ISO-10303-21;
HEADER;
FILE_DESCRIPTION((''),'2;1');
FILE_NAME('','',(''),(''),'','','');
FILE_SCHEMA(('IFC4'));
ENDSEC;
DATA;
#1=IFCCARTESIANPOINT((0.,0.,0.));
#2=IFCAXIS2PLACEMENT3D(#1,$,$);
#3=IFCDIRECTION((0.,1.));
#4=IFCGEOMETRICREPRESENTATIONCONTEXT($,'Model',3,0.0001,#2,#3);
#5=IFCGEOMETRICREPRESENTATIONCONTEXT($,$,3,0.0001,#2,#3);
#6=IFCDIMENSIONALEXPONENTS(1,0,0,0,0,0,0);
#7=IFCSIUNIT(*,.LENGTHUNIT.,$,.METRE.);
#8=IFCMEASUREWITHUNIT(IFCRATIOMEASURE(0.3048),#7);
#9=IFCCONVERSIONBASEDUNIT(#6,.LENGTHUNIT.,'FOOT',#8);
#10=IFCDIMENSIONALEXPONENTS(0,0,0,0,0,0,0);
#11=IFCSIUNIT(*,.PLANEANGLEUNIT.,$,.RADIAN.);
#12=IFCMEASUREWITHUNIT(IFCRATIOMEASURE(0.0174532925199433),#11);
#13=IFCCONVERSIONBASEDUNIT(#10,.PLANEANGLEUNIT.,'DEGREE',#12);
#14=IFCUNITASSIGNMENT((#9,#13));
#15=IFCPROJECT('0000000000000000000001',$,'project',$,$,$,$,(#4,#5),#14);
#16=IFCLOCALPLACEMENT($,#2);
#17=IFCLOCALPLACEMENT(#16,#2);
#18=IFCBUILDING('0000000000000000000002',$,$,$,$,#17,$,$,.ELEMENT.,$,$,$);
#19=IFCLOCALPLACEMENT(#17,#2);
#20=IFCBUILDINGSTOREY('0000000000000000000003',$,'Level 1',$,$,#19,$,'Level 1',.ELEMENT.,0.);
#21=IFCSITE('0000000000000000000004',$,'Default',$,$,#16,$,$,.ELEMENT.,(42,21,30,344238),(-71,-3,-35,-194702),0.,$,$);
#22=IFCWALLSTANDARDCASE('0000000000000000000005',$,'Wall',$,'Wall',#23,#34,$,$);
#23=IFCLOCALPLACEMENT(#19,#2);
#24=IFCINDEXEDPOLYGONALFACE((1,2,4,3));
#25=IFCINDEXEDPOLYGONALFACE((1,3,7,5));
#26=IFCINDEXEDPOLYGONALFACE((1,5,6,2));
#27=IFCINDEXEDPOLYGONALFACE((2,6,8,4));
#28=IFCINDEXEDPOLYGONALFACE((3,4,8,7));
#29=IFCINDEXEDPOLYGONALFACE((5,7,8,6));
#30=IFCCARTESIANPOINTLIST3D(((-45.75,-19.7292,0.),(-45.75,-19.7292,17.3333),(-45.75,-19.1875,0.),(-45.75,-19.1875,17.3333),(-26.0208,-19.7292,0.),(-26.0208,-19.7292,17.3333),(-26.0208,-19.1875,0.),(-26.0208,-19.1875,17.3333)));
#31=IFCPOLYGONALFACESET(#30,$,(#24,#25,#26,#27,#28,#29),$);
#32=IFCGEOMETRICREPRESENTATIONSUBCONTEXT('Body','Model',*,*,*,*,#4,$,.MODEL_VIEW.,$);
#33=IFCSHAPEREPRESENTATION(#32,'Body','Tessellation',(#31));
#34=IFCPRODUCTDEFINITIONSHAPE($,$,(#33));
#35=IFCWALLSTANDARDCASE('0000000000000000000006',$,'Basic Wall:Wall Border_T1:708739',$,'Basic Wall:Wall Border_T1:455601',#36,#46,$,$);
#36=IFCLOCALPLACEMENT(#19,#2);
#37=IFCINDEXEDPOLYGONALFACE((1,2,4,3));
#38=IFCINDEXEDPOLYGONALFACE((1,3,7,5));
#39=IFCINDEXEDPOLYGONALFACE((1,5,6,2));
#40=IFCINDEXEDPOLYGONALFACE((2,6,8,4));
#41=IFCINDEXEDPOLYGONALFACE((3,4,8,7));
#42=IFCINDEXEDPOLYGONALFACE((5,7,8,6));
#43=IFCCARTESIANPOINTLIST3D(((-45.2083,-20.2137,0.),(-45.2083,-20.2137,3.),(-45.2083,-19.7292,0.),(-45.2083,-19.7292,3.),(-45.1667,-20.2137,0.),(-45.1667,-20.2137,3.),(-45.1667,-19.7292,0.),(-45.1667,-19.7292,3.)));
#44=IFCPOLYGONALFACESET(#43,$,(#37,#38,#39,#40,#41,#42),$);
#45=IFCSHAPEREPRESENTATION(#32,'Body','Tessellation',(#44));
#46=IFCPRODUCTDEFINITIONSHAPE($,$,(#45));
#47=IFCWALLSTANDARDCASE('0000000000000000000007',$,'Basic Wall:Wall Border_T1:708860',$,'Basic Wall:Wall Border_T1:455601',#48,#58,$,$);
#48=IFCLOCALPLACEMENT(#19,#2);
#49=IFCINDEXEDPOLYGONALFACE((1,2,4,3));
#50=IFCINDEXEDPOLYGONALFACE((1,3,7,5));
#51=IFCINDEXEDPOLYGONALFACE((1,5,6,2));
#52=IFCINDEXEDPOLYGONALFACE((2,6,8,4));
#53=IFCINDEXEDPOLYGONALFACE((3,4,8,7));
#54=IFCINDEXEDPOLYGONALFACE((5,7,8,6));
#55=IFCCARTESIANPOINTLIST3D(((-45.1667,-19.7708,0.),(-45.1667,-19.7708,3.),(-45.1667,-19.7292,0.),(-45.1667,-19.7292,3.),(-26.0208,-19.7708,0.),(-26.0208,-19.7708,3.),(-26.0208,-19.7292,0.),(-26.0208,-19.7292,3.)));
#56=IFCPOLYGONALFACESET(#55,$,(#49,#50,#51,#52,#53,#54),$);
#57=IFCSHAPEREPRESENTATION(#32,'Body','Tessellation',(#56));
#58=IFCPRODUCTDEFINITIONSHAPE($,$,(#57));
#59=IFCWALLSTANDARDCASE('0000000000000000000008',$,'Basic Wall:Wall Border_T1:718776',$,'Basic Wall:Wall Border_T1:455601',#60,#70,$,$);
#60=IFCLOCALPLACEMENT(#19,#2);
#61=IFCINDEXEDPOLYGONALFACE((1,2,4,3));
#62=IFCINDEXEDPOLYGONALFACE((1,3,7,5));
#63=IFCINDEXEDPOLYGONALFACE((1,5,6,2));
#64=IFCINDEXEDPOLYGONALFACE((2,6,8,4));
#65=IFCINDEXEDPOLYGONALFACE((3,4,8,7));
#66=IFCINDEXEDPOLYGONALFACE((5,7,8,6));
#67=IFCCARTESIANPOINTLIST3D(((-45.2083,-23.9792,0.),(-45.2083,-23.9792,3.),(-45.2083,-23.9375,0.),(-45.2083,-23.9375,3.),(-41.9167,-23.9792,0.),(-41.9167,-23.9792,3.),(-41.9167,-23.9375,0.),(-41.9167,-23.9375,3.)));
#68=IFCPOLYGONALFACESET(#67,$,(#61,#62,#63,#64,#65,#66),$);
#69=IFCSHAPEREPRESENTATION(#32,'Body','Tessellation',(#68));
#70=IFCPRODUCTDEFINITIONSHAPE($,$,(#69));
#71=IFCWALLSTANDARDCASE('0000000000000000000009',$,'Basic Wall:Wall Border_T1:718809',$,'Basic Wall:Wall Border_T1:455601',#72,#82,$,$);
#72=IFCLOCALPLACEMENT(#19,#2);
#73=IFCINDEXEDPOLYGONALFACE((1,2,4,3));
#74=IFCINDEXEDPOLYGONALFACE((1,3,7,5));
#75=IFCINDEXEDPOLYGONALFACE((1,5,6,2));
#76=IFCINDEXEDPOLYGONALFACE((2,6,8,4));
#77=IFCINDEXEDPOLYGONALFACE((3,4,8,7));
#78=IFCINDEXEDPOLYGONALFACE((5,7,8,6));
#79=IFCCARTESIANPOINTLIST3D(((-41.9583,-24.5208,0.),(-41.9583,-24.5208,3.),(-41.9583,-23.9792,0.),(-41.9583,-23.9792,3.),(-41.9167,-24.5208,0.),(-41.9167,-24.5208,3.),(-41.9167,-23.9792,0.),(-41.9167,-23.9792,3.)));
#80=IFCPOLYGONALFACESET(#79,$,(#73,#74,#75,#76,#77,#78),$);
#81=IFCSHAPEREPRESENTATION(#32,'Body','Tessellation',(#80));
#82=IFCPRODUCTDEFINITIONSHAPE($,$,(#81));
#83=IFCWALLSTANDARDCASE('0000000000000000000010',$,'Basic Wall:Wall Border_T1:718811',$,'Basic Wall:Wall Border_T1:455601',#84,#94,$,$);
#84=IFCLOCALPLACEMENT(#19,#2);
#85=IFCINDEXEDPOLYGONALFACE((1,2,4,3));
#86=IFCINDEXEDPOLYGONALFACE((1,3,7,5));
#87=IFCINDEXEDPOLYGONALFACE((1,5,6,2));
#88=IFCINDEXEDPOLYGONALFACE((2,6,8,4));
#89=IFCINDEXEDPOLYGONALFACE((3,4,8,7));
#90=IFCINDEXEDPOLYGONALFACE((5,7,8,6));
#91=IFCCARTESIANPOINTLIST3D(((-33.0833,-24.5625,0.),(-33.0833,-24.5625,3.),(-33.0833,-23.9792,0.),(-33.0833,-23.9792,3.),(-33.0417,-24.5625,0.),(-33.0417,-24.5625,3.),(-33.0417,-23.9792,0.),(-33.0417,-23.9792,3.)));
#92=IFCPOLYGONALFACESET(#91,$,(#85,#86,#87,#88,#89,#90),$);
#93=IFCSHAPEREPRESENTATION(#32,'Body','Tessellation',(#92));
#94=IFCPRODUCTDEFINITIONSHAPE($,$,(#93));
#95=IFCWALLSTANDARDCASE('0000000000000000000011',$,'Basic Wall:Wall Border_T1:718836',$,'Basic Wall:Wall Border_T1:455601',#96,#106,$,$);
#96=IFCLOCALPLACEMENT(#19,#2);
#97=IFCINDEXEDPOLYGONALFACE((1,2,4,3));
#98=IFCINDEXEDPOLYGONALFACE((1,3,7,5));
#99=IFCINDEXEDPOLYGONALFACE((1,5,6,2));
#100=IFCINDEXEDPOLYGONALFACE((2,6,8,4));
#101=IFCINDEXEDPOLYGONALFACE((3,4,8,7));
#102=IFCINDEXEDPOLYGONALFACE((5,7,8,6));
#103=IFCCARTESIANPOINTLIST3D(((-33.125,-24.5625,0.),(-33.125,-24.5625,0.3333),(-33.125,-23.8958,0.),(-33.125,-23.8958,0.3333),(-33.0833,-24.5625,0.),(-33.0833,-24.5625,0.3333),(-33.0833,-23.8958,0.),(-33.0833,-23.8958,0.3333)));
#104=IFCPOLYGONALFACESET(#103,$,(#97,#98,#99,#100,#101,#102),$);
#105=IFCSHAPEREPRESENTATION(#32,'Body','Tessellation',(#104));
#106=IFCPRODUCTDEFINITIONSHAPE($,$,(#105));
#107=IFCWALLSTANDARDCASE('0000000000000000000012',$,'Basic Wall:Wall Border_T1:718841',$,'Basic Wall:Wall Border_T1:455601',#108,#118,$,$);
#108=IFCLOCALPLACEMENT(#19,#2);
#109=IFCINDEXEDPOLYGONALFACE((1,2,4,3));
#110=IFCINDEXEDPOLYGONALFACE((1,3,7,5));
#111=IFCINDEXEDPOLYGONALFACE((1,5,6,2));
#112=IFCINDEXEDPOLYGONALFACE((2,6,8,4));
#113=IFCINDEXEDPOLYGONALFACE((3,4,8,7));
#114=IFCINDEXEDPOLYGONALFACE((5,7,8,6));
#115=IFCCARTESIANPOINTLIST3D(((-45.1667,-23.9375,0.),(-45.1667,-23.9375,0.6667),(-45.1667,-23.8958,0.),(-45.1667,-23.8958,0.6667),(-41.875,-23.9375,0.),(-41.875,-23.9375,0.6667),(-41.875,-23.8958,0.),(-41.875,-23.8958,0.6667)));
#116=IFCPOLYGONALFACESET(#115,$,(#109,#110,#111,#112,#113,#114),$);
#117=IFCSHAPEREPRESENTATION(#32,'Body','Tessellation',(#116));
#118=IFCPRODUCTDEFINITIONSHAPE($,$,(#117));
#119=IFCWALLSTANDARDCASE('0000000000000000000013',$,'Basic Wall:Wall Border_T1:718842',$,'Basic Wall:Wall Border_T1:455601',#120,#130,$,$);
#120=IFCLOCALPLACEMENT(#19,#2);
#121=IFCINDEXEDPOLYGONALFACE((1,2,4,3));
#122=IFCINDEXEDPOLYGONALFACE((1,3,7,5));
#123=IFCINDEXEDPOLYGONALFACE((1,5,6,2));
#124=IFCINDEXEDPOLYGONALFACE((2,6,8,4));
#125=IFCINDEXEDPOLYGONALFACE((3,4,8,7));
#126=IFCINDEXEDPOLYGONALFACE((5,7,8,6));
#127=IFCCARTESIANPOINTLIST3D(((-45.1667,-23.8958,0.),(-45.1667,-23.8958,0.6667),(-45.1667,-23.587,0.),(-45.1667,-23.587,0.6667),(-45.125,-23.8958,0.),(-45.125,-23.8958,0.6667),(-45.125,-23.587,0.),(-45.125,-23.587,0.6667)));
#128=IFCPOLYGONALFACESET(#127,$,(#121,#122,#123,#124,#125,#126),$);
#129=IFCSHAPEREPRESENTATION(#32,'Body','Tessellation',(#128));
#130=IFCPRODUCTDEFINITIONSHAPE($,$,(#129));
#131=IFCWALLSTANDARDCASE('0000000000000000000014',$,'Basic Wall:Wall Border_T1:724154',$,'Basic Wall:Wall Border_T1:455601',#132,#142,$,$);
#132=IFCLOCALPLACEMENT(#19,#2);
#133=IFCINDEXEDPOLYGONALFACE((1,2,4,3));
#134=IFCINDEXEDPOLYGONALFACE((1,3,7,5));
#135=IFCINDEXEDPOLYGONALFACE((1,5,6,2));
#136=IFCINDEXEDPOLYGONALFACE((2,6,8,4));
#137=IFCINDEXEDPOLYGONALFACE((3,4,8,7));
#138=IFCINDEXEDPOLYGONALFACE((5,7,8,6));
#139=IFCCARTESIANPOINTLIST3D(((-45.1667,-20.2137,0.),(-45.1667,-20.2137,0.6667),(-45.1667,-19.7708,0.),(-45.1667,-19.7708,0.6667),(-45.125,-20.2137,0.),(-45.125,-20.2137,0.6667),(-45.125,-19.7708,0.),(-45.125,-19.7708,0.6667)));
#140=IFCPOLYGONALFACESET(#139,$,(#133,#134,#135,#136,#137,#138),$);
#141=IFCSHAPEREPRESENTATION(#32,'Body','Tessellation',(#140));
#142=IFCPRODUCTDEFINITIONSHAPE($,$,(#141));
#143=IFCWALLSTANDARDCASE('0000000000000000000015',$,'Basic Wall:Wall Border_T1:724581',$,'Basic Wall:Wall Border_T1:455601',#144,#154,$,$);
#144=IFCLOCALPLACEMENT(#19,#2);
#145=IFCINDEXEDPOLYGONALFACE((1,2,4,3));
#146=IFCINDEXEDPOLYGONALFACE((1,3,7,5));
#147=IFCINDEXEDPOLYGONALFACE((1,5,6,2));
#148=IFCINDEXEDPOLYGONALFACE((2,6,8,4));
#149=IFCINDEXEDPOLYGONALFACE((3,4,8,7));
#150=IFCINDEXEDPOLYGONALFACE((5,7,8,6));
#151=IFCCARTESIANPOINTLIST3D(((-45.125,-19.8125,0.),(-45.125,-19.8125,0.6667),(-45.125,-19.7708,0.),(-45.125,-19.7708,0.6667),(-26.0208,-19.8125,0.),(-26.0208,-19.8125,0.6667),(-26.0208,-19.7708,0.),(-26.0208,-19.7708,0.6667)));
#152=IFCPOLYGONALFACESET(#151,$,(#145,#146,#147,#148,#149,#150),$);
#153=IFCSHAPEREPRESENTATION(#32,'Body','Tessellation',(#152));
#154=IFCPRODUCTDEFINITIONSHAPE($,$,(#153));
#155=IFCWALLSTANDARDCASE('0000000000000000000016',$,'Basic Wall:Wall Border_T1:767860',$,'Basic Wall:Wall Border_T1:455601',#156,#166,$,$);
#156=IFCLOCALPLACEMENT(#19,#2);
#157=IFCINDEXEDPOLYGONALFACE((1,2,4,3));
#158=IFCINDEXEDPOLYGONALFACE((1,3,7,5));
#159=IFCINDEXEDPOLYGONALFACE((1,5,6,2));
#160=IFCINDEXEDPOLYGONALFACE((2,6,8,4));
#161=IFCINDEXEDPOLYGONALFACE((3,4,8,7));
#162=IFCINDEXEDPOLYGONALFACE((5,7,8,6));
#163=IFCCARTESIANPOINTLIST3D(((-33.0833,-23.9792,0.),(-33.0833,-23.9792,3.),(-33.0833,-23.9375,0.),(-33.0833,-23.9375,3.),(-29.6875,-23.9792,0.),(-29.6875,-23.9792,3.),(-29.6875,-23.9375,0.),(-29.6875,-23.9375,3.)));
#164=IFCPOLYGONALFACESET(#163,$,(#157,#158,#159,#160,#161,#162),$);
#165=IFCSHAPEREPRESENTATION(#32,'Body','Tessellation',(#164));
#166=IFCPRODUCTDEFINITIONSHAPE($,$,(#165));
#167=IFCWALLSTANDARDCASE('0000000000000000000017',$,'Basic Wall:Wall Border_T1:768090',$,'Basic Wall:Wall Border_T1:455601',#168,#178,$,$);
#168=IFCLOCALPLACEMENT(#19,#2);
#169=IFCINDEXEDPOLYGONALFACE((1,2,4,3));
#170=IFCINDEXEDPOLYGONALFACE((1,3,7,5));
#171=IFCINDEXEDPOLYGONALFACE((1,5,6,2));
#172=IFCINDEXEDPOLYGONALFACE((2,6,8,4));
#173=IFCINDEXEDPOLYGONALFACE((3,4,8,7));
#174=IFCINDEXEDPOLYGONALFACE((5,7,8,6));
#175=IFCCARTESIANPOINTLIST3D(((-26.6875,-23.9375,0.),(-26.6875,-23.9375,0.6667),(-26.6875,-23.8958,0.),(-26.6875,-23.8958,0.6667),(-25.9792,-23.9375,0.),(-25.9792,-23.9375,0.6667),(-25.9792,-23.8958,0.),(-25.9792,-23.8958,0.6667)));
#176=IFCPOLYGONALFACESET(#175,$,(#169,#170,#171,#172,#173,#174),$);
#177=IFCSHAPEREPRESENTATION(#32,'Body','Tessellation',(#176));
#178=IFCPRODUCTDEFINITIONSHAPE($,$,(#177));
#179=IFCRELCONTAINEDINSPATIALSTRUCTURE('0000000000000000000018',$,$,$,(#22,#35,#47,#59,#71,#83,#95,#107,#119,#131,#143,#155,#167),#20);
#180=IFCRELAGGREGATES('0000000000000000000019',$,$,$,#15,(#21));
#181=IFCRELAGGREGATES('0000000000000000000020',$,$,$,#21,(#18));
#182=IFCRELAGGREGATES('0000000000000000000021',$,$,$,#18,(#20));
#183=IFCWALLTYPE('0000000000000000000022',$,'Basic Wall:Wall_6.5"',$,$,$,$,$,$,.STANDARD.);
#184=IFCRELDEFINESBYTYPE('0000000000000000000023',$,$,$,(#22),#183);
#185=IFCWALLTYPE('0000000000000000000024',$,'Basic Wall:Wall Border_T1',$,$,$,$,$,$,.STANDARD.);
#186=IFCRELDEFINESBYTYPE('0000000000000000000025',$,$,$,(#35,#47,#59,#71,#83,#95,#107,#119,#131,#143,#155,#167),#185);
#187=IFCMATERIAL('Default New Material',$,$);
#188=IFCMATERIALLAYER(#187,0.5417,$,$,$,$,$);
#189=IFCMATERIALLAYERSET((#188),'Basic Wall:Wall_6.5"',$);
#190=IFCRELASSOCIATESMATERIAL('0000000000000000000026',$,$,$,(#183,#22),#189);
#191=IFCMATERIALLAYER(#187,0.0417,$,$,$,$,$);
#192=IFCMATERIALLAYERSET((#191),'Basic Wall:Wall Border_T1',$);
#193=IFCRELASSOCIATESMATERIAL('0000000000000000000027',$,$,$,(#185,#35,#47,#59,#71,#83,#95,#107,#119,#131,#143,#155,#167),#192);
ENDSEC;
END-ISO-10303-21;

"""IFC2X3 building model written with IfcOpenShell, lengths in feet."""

from ifc_helpers import new_model, entity, si_unit, converted_unit, direction, frame, frame_2d, origin, place, context, subcontext, project, spatial, rectangle, extrude, material, layer, layer_set, layer_usage, type_object, element, save


model = new_model("IFC2X3")

# Units and contexts
model_context = context("Model", 3, precision=0.0001, world=origin(), true_north=direction((0.0, 1.0)))
context_of_model = context(None, 3, precision=0.0001, world=origin(), true_north=direction((0.0, 1.0)))
body_context = subcontext(model_context, "Body", "Model", "MODEL_VIEW")
ifc_project = project(units=[converted_unit("LENGTHUNIT", "FOOT", entity("IfcRatioMeasure", 0.3048), si_unit("LENGTHUNIT", "METRE"), dimensions=[1, 0, 0, 0, 0, 0, 0]), converted_unit("PLANEANGLEUNIT", "DEGREE", entity("IfcRatioMeasure", 0.0174532925199433), si_unit("PLANEANGLEUNIT", "RADIAN"), dimensions=[0, 0, 0, 0, 0, 0, 0])], contexts=[model_context, context_of_model])

# Site, building, storey
site_placement = place(None, origin())
site = spatial("IfcSite", under=ifc_project, at=site_placement, Name="Default", CompositionType="ELEMENT", RefLatitude=(42, 21, 30, 344238), RefLongitude=(-71, -3, -35, -194702), RefElevation=0.0)
building_placement = place(site_placement, origin())
building = spatial("IfcBuilding", under=site, at=building_placement, CompositionType="ELEMENT")
storey_placement = place(building_placement, origin())
storey = spatial("IfcBuildingStorey", under=building, at=storey_placement, Name="Level 1", LongName="Level 1", CompositionType="ELEMENT", Elevation=0.0)

# Wall
ifc_material_1 = material(Name="Default New Material")
ifc_layer_1 = layer(ifc_material_1, 0.5417)
ifc_layer_set_1 = layer_set([ifc_layer_1], Name="Basic Wall:Wall_6.5\"")
ifc_layer_usage_1 = layer_usage(ifc_layer_set_1, "AXIS2", "NEGATIVE", 0.2708)
wall_type_1 = type_object("IfcWallType", Name="Basic Wall:Wall_6.5\"", PredefinedType="STANDARD", material=ifc_layer_set_1)
wall_1_placement = place(storey_placement, frame((-45.75, -19.4583, 0.0)))
element("IfcWallStandardCase", 1, at=wall_1_placement, inside=storey, type_object=wall_type_1, material=ifc_layer_usage_1, Name="Wall", ObjectType="Wall", context=body_context, shape_type="SweptSolid", body=[
    extrude(rectangle(XDim=19.7292, YDim=0.5417, at=frame_2d((9.8646, 0.0), x_axis=(-1.0, 0.0))), origin(), (0.0, 0.0, 1.0), 17.3333),
])

# Walls
ifc_layer_2 = layer(ifc_material_1, 0.0417)
ifc_layer_set_2 = layer_set([ifc_layer_2], Name="Basic Wall:Wall Border_T1")
ifc_layer_usage_2 = layer_usage(ifc_layer_set_2, "AXIS2", "POSITIVE", -0.0208)
wall_type_2 = type_object("IfcWallType", Name="Basic Wall:Wall Border_T1", PredefinedType="STANDARD", material=ifc_layer_set_2)
wall_2_placement = place(storey_placement, frame((-45.1875, -20.2137, 0.0), z_axis=(0.0, 0.0, 1.0), x_axis=(0.0, 1.0, 0.0)))
element("IfcWallStandardCase", 2, at=wall_2_placement, inside=storey, type_object=wall_type_2, material=ifc_layer_usage_2, Name="Basic Wall:Wall Border_T1:708739", ObjectType="Basic Wall:Wall Border_T1:455601", context=body_context, shape_type="SweptSolid", body=[
    extrude(rectangle(XDim=0.4845, YDim=0.0417, at=frame_2d((0.2423, 0.0), x_axis=(-1.0, 0.0))), origin(), (0.0, 0.0, 1.0), 3.0),
])
ifc_layer_usage_3 = layer_usage(ifc_layer_set_2, "AXIS2", "POSITIVE", -0.0208)
wall_3_placement = place(storey_placement, frame((-45.1667, -19.75, 0.0)))
element("IfcWallStandardCase", 3, at=wall_3_placement, inside=storey, type_object=wall_type_2, material=ifc_layer_usage_3, Name="Basic Wall:Wall Border_T1:708860", ObjectType="Basic Wall:Wall Border_T1:455601", context=body_context, shape_type="SweptSolid", body=[
    extrude(rectangle(XDim=19.1458, YDim=0.0417, at=frame_2d((9.5729, 0.0), x_axis=(-1.0, 0.0))), origin(), (0.0, 0.0, 1.0), 3.0),
])
ifc_layer_usage_4 = layer_usage(ifc_layer_set_2, "AXIS2", "NEGATIVE", 0.0208)
wall_4_placement = place(storey_placement, frame((-45.2083, -23.9583, 0.0)))
element("IfcWallStandardCase", 4, at=wall_4_placement, inside=storey, type_object=wall_type_2, material=ifc_layer_usage_4, Name="Basic Wall:Wall Border_T1:718776", ObjectType="Basic Wall:Wall Border_T1:455601", context=body_context, shape_type="SweptSolid", body=[
    extrude(rectangle(XDim=3.2917, YDim=0.0417, at=frame_2d((1.6458, 0.0), x_axis=(-1.0, 0.0))), origin(), (0.0, 0.0, 1.0), 3.0),
])
ifc_layer_usage_5 = layer_usage(ifc_layer_set_2, "AXIS2", "NEGATIVE", 0.0208)
wall_5_placement = place(storey_placement, frame((-41.9375, -23.9792, 0.0), z_axis=(0.0, 0.0, 1.0), x_axis=(0.0, -1.0, 0.0)))
element("IfcWallStandardCase", 5, at=wall_5_placement, inside=storey, type_object=wall_type_2, material=ifc_layer_usage_5, Name="Basic Wall:Wall Border_T1:718809", ObjectType="Basic Wall:Wall Border_T1:455601", context=body_context, shape_type="SweptSolid", body=[
    extrude(rectangle(XDim=0.5417, YDim=0.0417, at=frame_2d((0.2708, 0.0), x_axis=(-1.0, 0.0))), origin(), (0.0, 0.0, 1.0), 3.0),
])
ifc_layer_usage_6 = layer_usage(ifc_layer_set_2, "AXIS2", "POSITIVE", -0.0208)
wall_6_placement = place(storey_placement, frame((-33.0625, -23.9792, 0.0), z_axis=(0.0, 0.0, 1.0), x_axis=(0.0, -1.0, 0.0)))
element("IfcWallStandardCase", 6, at=wall_6_placement, inside=storey, type_object=wall_type_2, material=ifc_layer_usage_6, Name="Basic Wall:Wall Border_T1:718811", ObjectType="Basic Wall:Wall Border_T1:455601", context=body_context, shape_type="SweptSolid", body=[
    extrude(rectangle(XDim=0.5833, YDim=0.0417, at=frame_2d((0.2917, 0.0), x_axis=(-1.0, 0.0))), origin(), (0.0, 0.0, 1.0), 3.0),
])
ifc_layer_usage_7 = layer_usage(ifc_layer_set_2, "AXIS2", "POSITIVE", -0.0208)
wall_7_placement = place(storey_placement, frame((-33.1042, -23.8958, 0.0), z_axis=(0.0, 0.0, 1.0), x_axis=(0.0, -1.0, 0.0)))
element("IfcWallStandardCase", 7, at=wall_7_placement, inside=storey, type_object=wall_type_2, material=ifc_layer_usage_7, Name="Basic Wall:Wall Border_T1:718836", ObjectType="Basic Wall:Wall Border_T1:455601", context=body_context, shape_type="SweptSolid", body=[
    extrude(rectangle(XDim=0.6667, YDim=0.0417, at=frame_2d((0.3333, 0.0), x_axis=(-1.0, 0.0))), origin(), (0.0, 0.0, 1.0), 0.3333),
])
ifc_layer_usage_8 = layer_usage(ifc_layer_set_2, "AXIS2", "NEGATIVE", 0.0208)
wall_8_placement = place(storey_placement, frame((-45.1667, -23.9167, 0.0)))
element("IfcWallStandardCase", 8, at=wall_8_placement, inside=storey, type_object=wall_type_2, material=ifc_layer_usage_8, Name="Basic Wall:Wall Border_T1:718841", ObjectType="Basic Wall:Wall Border_T1:455601", context=body_context, shape_type="SweptSolid", body=[
    extrude(rectangle(XDim=3.2917, YDim=0.0417, at=frame_2d((1.6458, 0.0), x_axis=(-1.0, 0.0))), origin(), (0.0, 0.0, 1.0), 0.6667),
])
ifc_layer_usage_9 = layer_usage(ifc_layer_set_2, "AXIS2", "POSITIVE", -0.0208)
wall_9_placement = place(storey_placement, frame((-45.1458, -23.8958, 0.0), z_axis=(0.0, 0.0, 1.0), x_axis=(0.0, 1.0, 0.0)))
element("IfcWallStandardCase", 9, at=wall_9_placement, inside=storey, type_object=wall_type_2, material=ifc_layer_usage_9, Name="Basic Wall:Wall Border_T1:718842", ObjectType="Basic Wall:Wall Border_T1:455601", context=body_context, shape_type="SweptSolid", body=[
    extrude(rectangle(XDim=0.3089, YDim=0.0417, at=frame_2d((0.1544, 0.0), x_axis=(-1.0, 0.0))), origin(), (0.0, 0.0, 1.0), 0.6667),
])
ifc_layer_usage_10 = layer_usage(ifc_layer_set_2, "AXIS2", "POSITIVE", -0.0208)
wall_10_placement = place(storey_placement, frame((-45.1458, -20.2137, 0.0), z_axis=(0.0, 0.0, 1.0), x_axis=(0.0, 1.0, 0.0)))
element("IfcWallStandardCase", 10, at=wall_10_placement, inside=storey, type_object=wall_type_2, material=ifc_layer_usage_10, Name="Basic Wall:Wall Border_T1:724154", ObjectType="Basic Wall:Wall Border_T1:455601", context=body_context, shape_type="SweptSolid", body=[
    extrude(rectangle(XDim=0.4428, YDim=0.0417, at=frame_2d((0.2214, 0.0), x_axis=(-1.0, 0.0))), origin(), (0.0, 0.0, 1.0), 0.6667),
])
ifc_layer_usage_11 = layer_usage(ifc_layer_set_2, "AXIS2", "NEGATIVE", 0.0208)
wall_11_placement = place(storey_placement, frame((-45.125, -19.7917, 0.0)))
element("IfcWallStandardCase", 11, at=wall_11_placement, inside=storey, type_object=wall_type_2, material=ifc_layer_usage_11, Name="Basic Wall:Wall Border_T1:724581", ObjectType="Basic Wall:Wall Border_T1:455601", context=body_context, shape_type="SweptSolid", body=[
    extrude(rectangle(XDim=19.1042, YDim=0.0417, at=frame_2d((9.5521, 0.0), x_axis=(-1.0, 0.0))), origin(), (0.0, 0.0, 1.0), 0.6667),
])
ifc_layer_usage_12 = layer_usage(ifc_layer_set_2, "AXIS2", "POSITIVE", -0.0208)
wall_12_placement = place(storey_placement, frame((-29.6875, -23.9583, 0.0), z_axis=(0.0, 0.0, 1.0), x_axis=(-1.0, 0.0, 0.0)))
element("IfcWallStandardCase", 12, at=wall_12_placement, inside=storey, type_object=wall_type_2, material=ifc_layer_usage_12, Name="Basic Wall:Wall Border_T1:767860", ObjectType="Basic Wall:Wall Border_T1:455601", context=body_context, shape_type="SweptSolid", body=[
    extrude(rectangle(XDim=3.3958, YDim=0.0417, at=frame_2d((1.6979, 0.0), x_axis=(-1.0, 0.0))), origin(), (0.0, 0.0, 1.0), 3.0),
])
ifc_layer_usage_13 = layer_usage(ifc_layer_set_2, "AXIS2", "NEGATIVE", 0.0208)
wall_13_placement = place(storey_placement, frame((-26.6875, -23.9167, 0.0)))
element("IfcWallStandardCase", 13, at=wall_13_placement, inside=storey, type_object=wall_type_2, material=ifc_layer_usage_13, Name="Basic Wall:Wall Border_T1:768090", ObjectType="Basic Wall:Wall Border_T1:455601", context=body_context, shape_type="SweptSolid", body=[
    extrude(rectangle(XDim=0.7083, YDim=0.0417, at=frame_2d((0.3542, 0.0), x_axis=(-1.0, 0.0))), origin(), (0.0, 0.0, 1.0), 0.6667),
])

save(model, "model.ifc")
